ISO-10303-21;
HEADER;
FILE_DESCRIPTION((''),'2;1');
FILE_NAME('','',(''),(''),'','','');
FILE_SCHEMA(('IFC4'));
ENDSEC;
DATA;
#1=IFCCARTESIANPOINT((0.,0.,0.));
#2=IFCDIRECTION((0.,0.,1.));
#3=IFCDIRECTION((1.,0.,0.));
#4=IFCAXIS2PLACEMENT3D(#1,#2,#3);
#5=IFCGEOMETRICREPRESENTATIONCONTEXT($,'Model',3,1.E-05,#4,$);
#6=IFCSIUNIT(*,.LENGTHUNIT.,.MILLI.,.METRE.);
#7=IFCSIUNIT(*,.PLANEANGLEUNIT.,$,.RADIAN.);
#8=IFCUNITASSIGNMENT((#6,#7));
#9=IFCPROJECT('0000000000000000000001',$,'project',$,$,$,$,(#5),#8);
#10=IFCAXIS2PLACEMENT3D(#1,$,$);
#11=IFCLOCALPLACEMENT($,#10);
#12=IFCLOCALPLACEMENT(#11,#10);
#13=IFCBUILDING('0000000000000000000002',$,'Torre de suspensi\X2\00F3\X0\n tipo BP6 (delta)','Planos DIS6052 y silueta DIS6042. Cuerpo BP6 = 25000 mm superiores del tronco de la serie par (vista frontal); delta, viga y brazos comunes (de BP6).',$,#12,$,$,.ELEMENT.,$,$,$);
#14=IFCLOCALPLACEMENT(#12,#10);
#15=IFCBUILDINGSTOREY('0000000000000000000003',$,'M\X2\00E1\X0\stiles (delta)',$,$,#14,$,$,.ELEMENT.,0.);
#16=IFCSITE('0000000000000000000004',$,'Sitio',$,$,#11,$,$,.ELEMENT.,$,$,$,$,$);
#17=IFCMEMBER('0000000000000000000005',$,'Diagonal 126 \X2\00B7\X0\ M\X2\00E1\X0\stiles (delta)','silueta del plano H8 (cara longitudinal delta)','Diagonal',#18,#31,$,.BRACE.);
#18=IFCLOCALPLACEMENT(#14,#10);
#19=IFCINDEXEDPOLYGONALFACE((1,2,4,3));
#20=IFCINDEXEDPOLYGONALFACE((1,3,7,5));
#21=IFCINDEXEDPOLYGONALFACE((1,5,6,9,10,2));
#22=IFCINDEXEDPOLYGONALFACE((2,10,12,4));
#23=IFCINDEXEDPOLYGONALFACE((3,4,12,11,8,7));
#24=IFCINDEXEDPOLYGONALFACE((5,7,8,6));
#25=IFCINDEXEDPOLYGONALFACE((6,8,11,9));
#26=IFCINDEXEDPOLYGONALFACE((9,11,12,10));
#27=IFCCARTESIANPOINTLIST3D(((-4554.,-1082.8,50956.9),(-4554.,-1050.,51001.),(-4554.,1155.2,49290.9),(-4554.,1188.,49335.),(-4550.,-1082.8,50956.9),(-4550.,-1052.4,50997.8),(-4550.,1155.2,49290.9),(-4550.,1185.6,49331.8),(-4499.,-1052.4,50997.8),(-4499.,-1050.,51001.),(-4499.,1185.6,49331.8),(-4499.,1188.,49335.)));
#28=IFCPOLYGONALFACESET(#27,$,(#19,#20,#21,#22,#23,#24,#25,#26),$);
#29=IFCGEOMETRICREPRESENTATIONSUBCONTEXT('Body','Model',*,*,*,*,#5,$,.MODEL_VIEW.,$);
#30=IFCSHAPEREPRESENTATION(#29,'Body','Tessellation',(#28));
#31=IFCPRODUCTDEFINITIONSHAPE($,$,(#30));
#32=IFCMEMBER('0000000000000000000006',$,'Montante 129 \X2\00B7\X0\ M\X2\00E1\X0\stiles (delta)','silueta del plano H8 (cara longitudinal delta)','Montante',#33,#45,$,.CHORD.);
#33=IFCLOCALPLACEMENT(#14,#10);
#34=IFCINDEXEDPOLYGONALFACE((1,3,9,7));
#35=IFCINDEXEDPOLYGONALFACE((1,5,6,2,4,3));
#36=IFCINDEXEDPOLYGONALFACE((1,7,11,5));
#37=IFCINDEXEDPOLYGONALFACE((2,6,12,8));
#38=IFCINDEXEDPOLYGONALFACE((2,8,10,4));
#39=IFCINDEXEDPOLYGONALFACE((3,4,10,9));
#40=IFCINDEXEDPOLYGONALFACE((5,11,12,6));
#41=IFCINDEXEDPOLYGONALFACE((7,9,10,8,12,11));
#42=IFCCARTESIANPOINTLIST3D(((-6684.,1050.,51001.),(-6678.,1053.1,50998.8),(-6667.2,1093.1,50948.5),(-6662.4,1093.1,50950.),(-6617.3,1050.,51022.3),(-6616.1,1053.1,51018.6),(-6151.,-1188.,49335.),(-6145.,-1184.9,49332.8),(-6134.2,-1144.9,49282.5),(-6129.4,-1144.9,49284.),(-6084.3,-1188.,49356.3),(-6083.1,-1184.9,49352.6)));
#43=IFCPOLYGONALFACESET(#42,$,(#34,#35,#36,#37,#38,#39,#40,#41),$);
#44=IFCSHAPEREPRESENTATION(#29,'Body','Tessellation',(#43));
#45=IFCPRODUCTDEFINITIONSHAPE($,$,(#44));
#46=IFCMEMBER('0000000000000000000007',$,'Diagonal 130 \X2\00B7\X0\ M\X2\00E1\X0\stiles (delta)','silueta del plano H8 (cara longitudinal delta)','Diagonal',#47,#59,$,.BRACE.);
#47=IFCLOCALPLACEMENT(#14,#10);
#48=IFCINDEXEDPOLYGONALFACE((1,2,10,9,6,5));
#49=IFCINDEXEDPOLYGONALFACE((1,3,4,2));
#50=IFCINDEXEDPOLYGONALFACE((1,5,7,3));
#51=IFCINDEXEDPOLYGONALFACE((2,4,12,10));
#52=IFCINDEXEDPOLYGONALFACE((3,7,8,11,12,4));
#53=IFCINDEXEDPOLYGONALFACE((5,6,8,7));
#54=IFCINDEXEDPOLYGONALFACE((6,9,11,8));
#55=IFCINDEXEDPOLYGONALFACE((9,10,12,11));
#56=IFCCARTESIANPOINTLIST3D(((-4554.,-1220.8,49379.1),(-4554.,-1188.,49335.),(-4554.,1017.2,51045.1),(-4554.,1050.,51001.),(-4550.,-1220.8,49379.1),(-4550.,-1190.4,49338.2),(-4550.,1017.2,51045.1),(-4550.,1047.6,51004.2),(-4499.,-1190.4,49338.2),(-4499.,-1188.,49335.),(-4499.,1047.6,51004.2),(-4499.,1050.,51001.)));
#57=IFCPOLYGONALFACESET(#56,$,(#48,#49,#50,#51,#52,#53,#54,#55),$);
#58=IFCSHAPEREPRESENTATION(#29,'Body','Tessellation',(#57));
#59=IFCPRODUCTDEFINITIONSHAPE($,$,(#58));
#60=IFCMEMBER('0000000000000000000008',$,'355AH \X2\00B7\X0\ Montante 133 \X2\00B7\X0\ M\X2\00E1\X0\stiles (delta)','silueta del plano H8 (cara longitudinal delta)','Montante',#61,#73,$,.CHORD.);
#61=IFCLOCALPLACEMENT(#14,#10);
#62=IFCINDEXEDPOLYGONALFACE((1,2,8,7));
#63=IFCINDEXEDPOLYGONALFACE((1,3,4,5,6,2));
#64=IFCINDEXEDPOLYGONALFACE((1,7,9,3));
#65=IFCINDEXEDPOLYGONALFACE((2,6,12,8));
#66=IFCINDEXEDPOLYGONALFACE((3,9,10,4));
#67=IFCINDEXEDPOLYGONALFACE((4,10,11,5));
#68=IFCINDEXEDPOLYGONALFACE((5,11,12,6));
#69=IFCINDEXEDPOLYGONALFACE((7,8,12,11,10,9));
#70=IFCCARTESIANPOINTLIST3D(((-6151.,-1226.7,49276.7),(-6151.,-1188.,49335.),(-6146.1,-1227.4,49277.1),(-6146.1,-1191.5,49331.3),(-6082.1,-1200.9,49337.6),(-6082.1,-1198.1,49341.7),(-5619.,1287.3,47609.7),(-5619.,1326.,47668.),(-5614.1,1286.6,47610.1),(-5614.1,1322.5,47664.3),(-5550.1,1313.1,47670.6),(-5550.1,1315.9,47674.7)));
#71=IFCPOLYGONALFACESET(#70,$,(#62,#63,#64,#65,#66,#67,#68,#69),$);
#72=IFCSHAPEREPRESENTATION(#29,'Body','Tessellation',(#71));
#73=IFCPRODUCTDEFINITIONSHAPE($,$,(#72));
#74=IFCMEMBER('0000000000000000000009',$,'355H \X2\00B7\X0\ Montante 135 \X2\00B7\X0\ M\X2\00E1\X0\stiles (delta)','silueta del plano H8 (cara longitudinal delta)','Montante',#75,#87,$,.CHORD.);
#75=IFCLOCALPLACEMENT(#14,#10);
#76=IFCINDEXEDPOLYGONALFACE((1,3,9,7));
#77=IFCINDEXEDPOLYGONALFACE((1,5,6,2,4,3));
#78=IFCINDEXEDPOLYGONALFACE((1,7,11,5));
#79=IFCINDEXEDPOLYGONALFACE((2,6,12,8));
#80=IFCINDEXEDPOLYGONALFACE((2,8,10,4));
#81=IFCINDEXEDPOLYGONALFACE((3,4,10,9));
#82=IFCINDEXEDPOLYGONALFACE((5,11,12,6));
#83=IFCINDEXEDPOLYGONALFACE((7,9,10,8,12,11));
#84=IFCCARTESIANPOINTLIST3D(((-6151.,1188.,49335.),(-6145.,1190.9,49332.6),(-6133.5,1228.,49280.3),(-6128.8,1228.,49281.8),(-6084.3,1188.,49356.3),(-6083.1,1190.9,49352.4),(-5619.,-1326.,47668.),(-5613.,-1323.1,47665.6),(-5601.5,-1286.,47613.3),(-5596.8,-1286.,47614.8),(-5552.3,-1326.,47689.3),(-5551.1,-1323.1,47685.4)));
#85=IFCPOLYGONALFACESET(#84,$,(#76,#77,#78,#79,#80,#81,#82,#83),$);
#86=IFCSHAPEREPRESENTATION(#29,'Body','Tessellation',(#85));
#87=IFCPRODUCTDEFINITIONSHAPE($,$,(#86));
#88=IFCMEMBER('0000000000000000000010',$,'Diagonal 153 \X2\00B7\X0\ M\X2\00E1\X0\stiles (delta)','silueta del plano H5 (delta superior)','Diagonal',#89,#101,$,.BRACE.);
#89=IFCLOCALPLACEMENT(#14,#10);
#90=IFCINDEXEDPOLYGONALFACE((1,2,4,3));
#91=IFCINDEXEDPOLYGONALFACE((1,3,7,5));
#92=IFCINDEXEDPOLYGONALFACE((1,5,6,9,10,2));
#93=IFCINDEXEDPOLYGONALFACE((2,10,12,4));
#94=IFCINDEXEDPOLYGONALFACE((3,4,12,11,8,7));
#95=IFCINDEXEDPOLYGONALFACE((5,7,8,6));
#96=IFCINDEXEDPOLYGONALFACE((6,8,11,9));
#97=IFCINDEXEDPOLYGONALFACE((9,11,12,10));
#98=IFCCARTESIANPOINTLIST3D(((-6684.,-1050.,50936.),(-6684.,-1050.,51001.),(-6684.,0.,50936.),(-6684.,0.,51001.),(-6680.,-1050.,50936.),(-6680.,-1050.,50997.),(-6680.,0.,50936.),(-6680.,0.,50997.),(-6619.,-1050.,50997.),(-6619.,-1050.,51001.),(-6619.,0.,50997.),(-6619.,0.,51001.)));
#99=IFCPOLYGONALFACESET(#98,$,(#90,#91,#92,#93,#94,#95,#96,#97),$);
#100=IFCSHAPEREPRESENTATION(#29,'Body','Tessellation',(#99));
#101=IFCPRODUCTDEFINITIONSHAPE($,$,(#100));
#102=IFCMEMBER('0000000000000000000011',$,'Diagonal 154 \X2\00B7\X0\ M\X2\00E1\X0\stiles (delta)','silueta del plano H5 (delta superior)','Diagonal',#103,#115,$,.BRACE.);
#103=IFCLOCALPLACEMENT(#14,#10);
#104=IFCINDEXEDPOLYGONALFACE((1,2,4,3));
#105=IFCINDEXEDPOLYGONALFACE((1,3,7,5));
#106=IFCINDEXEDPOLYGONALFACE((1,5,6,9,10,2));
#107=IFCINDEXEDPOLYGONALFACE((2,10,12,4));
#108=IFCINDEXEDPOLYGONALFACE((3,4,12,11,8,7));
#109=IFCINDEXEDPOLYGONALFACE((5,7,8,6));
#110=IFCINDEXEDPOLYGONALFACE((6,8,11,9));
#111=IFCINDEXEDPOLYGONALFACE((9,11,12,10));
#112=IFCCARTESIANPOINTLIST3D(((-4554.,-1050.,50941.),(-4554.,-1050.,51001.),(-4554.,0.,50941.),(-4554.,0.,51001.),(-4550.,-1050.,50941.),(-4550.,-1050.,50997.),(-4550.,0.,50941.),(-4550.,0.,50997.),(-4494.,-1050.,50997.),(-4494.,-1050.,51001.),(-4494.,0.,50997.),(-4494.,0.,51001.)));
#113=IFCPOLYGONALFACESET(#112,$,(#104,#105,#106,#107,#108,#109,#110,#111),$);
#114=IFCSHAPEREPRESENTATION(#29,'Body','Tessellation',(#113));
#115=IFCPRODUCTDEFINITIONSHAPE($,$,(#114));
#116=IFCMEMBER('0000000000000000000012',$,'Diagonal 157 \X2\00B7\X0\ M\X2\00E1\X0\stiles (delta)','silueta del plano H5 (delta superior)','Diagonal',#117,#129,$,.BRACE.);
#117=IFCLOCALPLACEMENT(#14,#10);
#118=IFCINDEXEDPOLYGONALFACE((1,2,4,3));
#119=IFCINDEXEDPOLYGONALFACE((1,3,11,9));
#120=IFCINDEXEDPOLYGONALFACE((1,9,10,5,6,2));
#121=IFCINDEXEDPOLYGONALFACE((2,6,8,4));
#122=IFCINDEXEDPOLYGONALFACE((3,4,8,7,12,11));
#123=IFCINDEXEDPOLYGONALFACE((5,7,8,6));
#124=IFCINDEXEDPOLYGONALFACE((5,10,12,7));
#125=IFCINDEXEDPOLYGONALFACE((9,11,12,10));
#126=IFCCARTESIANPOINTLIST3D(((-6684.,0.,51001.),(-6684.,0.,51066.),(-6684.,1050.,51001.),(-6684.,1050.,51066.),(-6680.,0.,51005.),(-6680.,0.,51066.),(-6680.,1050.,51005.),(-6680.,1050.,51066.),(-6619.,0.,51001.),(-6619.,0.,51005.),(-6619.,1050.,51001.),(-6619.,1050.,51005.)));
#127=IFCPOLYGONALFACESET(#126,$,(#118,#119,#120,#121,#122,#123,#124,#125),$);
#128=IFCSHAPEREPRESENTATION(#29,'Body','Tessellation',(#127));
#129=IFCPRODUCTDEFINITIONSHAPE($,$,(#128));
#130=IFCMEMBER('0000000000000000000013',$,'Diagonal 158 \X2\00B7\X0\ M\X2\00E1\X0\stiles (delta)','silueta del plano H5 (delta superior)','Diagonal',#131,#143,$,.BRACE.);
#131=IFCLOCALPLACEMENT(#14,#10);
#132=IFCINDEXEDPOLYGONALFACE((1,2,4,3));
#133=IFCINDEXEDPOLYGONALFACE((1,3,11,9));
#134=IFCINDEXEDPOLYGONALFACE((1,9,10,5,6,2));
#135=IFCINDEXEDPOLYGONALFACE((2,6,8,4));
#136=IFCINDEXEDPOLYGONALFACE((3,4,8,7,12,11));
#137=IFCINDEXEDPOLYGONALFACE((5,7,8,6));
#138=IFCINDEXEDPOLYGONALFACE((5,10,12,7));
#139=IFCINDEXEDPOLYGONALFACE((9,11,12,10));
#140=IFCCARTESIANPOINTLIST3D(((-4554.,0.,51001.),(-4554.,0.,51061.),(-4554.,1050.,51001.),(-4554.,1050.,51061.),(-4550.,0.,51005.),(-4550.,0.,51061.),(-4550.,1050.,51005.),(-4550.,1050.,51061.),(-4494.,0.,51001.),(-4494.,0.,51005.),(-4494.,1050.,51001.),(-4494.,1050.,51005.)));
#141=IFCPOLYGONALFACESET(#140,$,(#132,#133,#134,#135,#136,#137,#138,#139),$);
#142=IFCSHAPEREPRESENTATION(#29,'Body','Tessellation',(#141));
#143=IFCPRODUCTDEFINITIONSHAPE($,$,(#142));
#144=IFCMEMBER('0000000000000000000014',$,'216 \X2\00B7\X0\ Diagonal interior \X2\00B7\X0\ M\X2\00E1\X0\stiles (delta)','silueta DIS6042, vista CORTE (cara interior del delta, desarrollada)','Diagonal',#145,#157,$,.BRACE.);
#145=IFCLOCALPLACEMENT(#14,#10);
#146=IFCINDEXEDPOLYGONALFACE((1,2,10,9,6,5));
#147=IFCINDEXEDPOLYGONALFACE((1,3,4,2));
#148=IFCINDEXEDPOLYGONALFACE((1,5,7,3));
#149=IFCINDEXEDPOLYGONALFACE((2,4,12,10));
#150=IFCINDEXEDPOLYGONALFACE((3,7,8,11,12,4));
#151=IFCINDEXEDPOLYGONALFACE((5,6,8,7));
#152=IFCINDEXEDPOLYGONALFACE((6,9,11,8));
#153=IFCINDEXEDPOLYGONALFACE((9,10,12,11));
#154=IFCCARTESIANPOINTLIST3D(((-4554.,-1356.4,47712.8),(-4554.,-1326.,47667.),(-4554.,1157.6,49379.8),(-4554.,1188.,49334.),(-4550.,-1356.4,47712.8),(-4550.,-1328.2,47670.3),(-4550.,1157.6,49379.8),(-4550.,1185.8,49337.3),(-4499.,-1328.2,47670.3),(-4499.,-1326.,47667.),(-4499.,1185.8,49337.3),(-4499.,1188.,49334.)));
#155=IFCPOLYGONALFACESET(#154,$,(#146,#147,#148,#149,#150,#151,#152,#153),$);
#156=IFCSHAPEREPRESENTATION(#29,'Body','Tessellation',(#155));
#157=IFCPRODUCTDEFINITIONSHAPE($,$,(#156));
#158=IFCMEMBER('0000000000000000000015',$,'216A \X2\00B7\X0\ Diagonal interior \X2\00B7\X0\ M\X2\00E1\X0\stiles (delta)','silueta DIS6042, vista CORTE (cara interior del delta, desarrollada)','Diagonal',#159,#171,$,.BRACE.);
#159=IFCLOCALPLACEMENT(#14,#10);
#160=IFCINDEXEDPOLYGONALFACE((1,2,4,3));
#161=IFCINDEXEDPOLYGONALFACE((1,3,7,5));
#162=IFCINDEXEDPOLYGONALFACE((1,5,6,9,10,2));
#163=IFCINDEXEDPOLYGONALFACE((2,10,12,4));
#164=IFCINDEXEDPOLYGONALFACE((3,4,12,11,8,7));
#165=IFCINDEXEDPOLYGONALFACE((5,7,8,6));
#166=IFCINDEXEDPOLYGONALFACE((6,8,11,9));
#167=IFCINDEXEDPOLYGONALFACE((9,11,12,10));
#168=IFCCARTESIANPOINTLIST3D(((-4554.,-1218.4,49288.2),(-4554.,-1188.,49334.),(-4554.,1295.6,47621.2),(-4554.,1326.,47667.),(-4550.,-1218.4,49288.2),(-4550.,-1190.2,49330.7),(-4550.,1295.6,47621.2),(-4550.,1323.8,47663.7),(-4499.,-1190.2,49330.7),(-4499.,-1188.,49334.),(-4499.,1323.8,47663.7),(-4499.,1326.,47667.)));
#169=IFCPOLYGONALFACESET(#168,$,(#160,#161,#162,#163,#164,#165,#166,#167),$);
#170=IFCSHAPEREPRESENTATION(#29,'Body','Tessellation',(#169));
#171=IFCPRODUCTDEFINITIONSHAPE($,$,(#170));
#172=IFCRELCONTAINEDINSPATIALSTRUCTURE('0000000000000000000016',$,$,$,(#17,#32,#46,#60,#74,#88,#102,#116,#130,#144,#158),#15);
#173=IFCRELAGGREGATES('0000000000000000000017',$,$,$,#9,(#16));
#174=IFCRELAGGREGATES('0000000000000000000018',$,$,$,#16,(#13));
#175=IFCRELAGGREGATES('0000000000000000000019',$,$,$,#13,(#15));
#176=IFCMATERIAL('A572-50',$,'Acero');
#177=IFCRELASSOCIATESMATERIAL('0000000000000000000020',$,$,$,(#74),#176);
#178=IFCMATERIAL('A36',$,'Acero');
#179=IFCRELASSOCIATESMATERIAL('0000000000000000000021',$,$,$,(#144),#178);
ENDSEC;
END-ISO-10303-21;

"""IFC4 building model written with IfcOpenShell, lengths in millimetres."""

from ifc_helpers import new_model, si_unit, frame, frame_2d, origin, origin_with_axes, place, context, subcontext, project, spatial, l_section, extrude, material, element, save


model = new_model("IFC4")

# Units and contexts
model_context = context("Model", 3, precision=1e-05, world=origin_with_axes())
body_context = subcontext(model_context, "Body", "Model", "MODEL_VIEW")
ifc_project = project(units=[si_unit("LENGTHUNIT", "METRE", prefix="MILLI"), si_unit("PLANEANGLEUNIT", "RADIAN")], contexts=[model_context])

# Site, building, storey
site_placement = place(None, origin())
site = spatial("IfcSite", under=ifc_project, at=site_placement, Name="Sitio", CompositionType="ELEMENT")
building_placement = place(site_placement, origin())
building = spatial("IfcBuilding", under=site, at=building_placement, Name="Torre de suspensión tipo BP6 (delta)", Description="Planos DIS6052 y silueta DIS6042. Cuerpo BP6 = 25000 mm superiores del tronco de la serie par (vista frontal); delta, viga y brazos comunes (de BP6).", CompositionType="ELEMENT")
storey_placement = place(building_placement, origin())
storey = spatial("IfcBuildingStorey", under=building, at=storey_placement, Name="Mástiles (delta)", CompositionType="ELEMENT", Elevation=0.0)

# Members
ifc_material_1 = material(Name="A572-50", Category="Acero")
ifc_material_2 = material(Name="A36", Category="Acero")
member_1_placement = place(storey_placement, frame((-4554.0, -1050.0, 51001.0), z_axis=(0.0, 0.802145, -0.597129), x_axis=(1.0, 0.0, 0.0)))
element("IfcMember", 1, at=member_1_placement, inside=storey, Name="Diagonal 126 · Mástiles (delta)", Description="silueta del plano H8 (cara longitudinal delta)", ObjectType="Diagonal", PredefinedType="BRACE", context=body_context, shape_type="SweptSolid", body=[
    extrude(l_section(Depth=55.0, Width=55.0, Thickness=4.0, at=frame_2d((27.5, 27.5))), None, (0.0, 0.0, 1.0), 2790.0),
])
member_2_placement = place(storey_placement, frame((-6684.0, 1050.0, 51001.0), z_axis=(0.187645, -0.787897, -0.586522), x_axis=(0.240083, 0.615807, -0.750428)))
element("IfcMember", 2, at=member_2_placement, inside=storey, Name="Montante 129 · Mástiles (delta)", Description="silueta del plano H8 (cara longitudinal delta)", ObjectType="Montante", PredefinedType="CHORD", context=body_context, shape_type="SweptSolid", body=[
    extrude(l_section(Depth=70.0, Width=70.0, Thickness=5.0, at=frame_2d((35.0, 35.0))), None, (0.0, 0.0, 1.0), 2840.5),
])
member_3_placement = place(storey_placement, frame((-4554.0, 1050.0, 51001.0), z_axis=(0.0, -0.802145, -0.597129), x_axis=(1.0, 0.0, 0.0)))
element("IfcMember", 3, at=member_3_placement, inside=storey, Name="Diagonal 130 · Mástiles (delta)", Description="silueta del plano H8 (cara longitudinal delta)", ObjectType="Diagonal", PredefinedType="BRACE", context=body_context, shape_type="SweptSolid", body=[
    extrude(l_section(Depth=55.0, Width=55.0, Thickness=4.0, at=frame_2d((27.5, 27.5))), None, (0.0, 0.0, 1.0), 2790.0),
])
member_4_placement = place(storey_placement, frame((-6151.0, -1188.0, 49335.0), z_axis=(0.173685, 0.820758, -0.544234), x_axis=(0.984801, -0.144753, 0.095984)))
element("IfcMember", 4, at=member_4_placement, inside=storey, Name="355AH · Montante 133 · Mástiles (delta)", Description="silueta del plano H8 (cara longitudinal delta)", ObjectType="Montante", PredefinedType="CHORD", context=body_context, shape_type="SweptSolid", body=[
    extrude(l_section(Depth=70.0, Width=70.0, Thickness=5.0, at=frame_2d((35.0, 35.0))), None, (0.0, 0.0, 1.0), 3063.0),
])
member_5_placement = place(storey_placement, frame((-6151.0, 1188.0, 49335.0), z_axis=(0.173685, -0.820758, -0.544234), x_axis=(0.249534, 0.571276, -0.781905)))
element("IfcMember", 5, at=member_5_placement, inside=storey, material=ifc_material_1, Name="355H · Montante 135 · Mástiles (delta)", Description="silueta del plano H8 (cara longitudinal delta)", ObjectType="Montante", PredefinedType="CHORD", context=body_context, shape_type="SweptSolid", body=[
    extrude(l_section(Depth=70.0, Width=70.0, Thickness=5.0, at=frame_2d((35.0, 35.0))), None, (0.0, 0.0, 1.0), 3063.0),
])
member_6_placement = place(storey_placement, frame((-6684.0, -1050.0, 51001.0), z_axis=(0.0, 1.0, 0.0), x_axis=(1.0, 0.0, 0.0)))
element("IfcMember", 6, at=member_6_placement, inside=storey, Name="Diagonal 153 · Mástiles (delta)", Description="silueta del plano H5 (delta superior)", ObjectType="Diagonal", PredefinedType="BRACE", context=body_context, shape_type="SweptSolid", body=[
    extrude(l_section(Depth=65.0, Width=65.0, Thickness=4.0, at=frame_2d((32.5, 32.5))), None, (0.0, 0.0, 1.0), 1050.0),
])
member_7_placement = place(storey_placement, frame((-4554.0, -1050.0, 51001.0), z_axis=(0.0, 1.0, 0.0), x_axis=(1.0, 0.0, 0.0)))
element("IfcMember", 7, at=member_7_placement, inside=storey, Name="Diagonal 154 · Mástiles (delta)", Description="silueta del plano H5 (delta superior)", ObjectType="Diagonal", PredefinedType="BRACE", context=body_context, shape_type="SweptSolid", body=[
    extrude(l_section(Depth=60.0, Width=60.0, Thickness=4.0, at=frame_2d((30.0, 30.0))), None, (0.0, 0.0, 1.0), 1050.0),
])
member_8_placement = place(storey_placement, frame((-6684.0, 1050.0, 51001.0), z_axis=(0.0, -1.0, 0.0), x_axis=(1.0, 0.0, 0.0)))
element("IfcMember", 8, at=member_8_placement, inside=storey, Name="Diagonal 157 · Mástiles (delta)", Description="silueta del plano H5 (delta superior)", ObjectType="Diagonal", PredefinedType="BRACE", context=body_context, shape_type="SweptSolid", body=[
    extrude(l_section(Depth=65.0, Width=65.0, Thickness=4.0, at=frame_2d((32.5, 32.5))), None, (0.0, 0.0, 1.0), 1050.0),
])
member_9_placement = place(storey_placement, frame((-4554.0, 1050.0, 51001.0), z_axis=(0.0, -1.0, 0.0), x_axis=(1.0, 0.0, 0.0)))
element("IfcMember", 9, at=member_9_placement, inside=storey, Name="Diagonal 158 · Mástiles (delta)", Description="silueta del plano H5 (delta superior)", ObjectType="Diagonal", PredefinedType="BRACE", context=body_context, shape_type="SweptSolid", body=[
    extrude(l_section(Depth=60.0, Width=60.0, Thickness=4.0, at=frame_2d((30.0, 30.0))), None, (0.0, 0.0, 1.0), 1050.0),
])
member_10_placement = place(storey_placement, frame((-4554.0, 1188.0, 49334.0), z_axis=(0.0, -0.833425, -0.552633), x_axis=(1.0, 0.0, 0.0)))
element("IfcMember", 10, at=member_10_placement, inside=storey, material=ifc_material_2, Name="216 · Diagonal interior · Mástiles (delta)", Description="silueta DIS6042, vista CORTE (cara interior del delta, desarrollada)", ObjectType="Diagonal", PredefinedType="BRACE", context=body_context, shape_type="SweptSolid", body=[
    extrude(l_section(Depth=55.0, Width=55.0, Thickness=4.0, at=frame_2d((27.5, 27.5))), None, (0.0, 0.0, 1.0), 3016.5),
])
member_11_placement = place(storey_placement, frame((-4554.0, -1188.0, 49334.0), z_axis=(0.0, 0.833425, -0.552633), x_axis=(1.0, 0.0, 0.0)))
element("IfcMember", 11, at=member_11_placement, inside=storey, Name="216A · Diagonal interior · Mástiles (delta)", Description="silueta DIS6042, vista CORTE (cara interior del delta, desarrollada)", ObjectType="Diagonal", PredefinedType="BRACE", context=body_context, shape_type="SweptSolid", body=[
    extrude(l_section(Depth=55.0, Width=55.0, Thickness=4.0, at=frame_2d((27.5, 27.5))), None, (0.0, 0.0, 1.0), 3016.5),
])

save(model, "model.ifc")
